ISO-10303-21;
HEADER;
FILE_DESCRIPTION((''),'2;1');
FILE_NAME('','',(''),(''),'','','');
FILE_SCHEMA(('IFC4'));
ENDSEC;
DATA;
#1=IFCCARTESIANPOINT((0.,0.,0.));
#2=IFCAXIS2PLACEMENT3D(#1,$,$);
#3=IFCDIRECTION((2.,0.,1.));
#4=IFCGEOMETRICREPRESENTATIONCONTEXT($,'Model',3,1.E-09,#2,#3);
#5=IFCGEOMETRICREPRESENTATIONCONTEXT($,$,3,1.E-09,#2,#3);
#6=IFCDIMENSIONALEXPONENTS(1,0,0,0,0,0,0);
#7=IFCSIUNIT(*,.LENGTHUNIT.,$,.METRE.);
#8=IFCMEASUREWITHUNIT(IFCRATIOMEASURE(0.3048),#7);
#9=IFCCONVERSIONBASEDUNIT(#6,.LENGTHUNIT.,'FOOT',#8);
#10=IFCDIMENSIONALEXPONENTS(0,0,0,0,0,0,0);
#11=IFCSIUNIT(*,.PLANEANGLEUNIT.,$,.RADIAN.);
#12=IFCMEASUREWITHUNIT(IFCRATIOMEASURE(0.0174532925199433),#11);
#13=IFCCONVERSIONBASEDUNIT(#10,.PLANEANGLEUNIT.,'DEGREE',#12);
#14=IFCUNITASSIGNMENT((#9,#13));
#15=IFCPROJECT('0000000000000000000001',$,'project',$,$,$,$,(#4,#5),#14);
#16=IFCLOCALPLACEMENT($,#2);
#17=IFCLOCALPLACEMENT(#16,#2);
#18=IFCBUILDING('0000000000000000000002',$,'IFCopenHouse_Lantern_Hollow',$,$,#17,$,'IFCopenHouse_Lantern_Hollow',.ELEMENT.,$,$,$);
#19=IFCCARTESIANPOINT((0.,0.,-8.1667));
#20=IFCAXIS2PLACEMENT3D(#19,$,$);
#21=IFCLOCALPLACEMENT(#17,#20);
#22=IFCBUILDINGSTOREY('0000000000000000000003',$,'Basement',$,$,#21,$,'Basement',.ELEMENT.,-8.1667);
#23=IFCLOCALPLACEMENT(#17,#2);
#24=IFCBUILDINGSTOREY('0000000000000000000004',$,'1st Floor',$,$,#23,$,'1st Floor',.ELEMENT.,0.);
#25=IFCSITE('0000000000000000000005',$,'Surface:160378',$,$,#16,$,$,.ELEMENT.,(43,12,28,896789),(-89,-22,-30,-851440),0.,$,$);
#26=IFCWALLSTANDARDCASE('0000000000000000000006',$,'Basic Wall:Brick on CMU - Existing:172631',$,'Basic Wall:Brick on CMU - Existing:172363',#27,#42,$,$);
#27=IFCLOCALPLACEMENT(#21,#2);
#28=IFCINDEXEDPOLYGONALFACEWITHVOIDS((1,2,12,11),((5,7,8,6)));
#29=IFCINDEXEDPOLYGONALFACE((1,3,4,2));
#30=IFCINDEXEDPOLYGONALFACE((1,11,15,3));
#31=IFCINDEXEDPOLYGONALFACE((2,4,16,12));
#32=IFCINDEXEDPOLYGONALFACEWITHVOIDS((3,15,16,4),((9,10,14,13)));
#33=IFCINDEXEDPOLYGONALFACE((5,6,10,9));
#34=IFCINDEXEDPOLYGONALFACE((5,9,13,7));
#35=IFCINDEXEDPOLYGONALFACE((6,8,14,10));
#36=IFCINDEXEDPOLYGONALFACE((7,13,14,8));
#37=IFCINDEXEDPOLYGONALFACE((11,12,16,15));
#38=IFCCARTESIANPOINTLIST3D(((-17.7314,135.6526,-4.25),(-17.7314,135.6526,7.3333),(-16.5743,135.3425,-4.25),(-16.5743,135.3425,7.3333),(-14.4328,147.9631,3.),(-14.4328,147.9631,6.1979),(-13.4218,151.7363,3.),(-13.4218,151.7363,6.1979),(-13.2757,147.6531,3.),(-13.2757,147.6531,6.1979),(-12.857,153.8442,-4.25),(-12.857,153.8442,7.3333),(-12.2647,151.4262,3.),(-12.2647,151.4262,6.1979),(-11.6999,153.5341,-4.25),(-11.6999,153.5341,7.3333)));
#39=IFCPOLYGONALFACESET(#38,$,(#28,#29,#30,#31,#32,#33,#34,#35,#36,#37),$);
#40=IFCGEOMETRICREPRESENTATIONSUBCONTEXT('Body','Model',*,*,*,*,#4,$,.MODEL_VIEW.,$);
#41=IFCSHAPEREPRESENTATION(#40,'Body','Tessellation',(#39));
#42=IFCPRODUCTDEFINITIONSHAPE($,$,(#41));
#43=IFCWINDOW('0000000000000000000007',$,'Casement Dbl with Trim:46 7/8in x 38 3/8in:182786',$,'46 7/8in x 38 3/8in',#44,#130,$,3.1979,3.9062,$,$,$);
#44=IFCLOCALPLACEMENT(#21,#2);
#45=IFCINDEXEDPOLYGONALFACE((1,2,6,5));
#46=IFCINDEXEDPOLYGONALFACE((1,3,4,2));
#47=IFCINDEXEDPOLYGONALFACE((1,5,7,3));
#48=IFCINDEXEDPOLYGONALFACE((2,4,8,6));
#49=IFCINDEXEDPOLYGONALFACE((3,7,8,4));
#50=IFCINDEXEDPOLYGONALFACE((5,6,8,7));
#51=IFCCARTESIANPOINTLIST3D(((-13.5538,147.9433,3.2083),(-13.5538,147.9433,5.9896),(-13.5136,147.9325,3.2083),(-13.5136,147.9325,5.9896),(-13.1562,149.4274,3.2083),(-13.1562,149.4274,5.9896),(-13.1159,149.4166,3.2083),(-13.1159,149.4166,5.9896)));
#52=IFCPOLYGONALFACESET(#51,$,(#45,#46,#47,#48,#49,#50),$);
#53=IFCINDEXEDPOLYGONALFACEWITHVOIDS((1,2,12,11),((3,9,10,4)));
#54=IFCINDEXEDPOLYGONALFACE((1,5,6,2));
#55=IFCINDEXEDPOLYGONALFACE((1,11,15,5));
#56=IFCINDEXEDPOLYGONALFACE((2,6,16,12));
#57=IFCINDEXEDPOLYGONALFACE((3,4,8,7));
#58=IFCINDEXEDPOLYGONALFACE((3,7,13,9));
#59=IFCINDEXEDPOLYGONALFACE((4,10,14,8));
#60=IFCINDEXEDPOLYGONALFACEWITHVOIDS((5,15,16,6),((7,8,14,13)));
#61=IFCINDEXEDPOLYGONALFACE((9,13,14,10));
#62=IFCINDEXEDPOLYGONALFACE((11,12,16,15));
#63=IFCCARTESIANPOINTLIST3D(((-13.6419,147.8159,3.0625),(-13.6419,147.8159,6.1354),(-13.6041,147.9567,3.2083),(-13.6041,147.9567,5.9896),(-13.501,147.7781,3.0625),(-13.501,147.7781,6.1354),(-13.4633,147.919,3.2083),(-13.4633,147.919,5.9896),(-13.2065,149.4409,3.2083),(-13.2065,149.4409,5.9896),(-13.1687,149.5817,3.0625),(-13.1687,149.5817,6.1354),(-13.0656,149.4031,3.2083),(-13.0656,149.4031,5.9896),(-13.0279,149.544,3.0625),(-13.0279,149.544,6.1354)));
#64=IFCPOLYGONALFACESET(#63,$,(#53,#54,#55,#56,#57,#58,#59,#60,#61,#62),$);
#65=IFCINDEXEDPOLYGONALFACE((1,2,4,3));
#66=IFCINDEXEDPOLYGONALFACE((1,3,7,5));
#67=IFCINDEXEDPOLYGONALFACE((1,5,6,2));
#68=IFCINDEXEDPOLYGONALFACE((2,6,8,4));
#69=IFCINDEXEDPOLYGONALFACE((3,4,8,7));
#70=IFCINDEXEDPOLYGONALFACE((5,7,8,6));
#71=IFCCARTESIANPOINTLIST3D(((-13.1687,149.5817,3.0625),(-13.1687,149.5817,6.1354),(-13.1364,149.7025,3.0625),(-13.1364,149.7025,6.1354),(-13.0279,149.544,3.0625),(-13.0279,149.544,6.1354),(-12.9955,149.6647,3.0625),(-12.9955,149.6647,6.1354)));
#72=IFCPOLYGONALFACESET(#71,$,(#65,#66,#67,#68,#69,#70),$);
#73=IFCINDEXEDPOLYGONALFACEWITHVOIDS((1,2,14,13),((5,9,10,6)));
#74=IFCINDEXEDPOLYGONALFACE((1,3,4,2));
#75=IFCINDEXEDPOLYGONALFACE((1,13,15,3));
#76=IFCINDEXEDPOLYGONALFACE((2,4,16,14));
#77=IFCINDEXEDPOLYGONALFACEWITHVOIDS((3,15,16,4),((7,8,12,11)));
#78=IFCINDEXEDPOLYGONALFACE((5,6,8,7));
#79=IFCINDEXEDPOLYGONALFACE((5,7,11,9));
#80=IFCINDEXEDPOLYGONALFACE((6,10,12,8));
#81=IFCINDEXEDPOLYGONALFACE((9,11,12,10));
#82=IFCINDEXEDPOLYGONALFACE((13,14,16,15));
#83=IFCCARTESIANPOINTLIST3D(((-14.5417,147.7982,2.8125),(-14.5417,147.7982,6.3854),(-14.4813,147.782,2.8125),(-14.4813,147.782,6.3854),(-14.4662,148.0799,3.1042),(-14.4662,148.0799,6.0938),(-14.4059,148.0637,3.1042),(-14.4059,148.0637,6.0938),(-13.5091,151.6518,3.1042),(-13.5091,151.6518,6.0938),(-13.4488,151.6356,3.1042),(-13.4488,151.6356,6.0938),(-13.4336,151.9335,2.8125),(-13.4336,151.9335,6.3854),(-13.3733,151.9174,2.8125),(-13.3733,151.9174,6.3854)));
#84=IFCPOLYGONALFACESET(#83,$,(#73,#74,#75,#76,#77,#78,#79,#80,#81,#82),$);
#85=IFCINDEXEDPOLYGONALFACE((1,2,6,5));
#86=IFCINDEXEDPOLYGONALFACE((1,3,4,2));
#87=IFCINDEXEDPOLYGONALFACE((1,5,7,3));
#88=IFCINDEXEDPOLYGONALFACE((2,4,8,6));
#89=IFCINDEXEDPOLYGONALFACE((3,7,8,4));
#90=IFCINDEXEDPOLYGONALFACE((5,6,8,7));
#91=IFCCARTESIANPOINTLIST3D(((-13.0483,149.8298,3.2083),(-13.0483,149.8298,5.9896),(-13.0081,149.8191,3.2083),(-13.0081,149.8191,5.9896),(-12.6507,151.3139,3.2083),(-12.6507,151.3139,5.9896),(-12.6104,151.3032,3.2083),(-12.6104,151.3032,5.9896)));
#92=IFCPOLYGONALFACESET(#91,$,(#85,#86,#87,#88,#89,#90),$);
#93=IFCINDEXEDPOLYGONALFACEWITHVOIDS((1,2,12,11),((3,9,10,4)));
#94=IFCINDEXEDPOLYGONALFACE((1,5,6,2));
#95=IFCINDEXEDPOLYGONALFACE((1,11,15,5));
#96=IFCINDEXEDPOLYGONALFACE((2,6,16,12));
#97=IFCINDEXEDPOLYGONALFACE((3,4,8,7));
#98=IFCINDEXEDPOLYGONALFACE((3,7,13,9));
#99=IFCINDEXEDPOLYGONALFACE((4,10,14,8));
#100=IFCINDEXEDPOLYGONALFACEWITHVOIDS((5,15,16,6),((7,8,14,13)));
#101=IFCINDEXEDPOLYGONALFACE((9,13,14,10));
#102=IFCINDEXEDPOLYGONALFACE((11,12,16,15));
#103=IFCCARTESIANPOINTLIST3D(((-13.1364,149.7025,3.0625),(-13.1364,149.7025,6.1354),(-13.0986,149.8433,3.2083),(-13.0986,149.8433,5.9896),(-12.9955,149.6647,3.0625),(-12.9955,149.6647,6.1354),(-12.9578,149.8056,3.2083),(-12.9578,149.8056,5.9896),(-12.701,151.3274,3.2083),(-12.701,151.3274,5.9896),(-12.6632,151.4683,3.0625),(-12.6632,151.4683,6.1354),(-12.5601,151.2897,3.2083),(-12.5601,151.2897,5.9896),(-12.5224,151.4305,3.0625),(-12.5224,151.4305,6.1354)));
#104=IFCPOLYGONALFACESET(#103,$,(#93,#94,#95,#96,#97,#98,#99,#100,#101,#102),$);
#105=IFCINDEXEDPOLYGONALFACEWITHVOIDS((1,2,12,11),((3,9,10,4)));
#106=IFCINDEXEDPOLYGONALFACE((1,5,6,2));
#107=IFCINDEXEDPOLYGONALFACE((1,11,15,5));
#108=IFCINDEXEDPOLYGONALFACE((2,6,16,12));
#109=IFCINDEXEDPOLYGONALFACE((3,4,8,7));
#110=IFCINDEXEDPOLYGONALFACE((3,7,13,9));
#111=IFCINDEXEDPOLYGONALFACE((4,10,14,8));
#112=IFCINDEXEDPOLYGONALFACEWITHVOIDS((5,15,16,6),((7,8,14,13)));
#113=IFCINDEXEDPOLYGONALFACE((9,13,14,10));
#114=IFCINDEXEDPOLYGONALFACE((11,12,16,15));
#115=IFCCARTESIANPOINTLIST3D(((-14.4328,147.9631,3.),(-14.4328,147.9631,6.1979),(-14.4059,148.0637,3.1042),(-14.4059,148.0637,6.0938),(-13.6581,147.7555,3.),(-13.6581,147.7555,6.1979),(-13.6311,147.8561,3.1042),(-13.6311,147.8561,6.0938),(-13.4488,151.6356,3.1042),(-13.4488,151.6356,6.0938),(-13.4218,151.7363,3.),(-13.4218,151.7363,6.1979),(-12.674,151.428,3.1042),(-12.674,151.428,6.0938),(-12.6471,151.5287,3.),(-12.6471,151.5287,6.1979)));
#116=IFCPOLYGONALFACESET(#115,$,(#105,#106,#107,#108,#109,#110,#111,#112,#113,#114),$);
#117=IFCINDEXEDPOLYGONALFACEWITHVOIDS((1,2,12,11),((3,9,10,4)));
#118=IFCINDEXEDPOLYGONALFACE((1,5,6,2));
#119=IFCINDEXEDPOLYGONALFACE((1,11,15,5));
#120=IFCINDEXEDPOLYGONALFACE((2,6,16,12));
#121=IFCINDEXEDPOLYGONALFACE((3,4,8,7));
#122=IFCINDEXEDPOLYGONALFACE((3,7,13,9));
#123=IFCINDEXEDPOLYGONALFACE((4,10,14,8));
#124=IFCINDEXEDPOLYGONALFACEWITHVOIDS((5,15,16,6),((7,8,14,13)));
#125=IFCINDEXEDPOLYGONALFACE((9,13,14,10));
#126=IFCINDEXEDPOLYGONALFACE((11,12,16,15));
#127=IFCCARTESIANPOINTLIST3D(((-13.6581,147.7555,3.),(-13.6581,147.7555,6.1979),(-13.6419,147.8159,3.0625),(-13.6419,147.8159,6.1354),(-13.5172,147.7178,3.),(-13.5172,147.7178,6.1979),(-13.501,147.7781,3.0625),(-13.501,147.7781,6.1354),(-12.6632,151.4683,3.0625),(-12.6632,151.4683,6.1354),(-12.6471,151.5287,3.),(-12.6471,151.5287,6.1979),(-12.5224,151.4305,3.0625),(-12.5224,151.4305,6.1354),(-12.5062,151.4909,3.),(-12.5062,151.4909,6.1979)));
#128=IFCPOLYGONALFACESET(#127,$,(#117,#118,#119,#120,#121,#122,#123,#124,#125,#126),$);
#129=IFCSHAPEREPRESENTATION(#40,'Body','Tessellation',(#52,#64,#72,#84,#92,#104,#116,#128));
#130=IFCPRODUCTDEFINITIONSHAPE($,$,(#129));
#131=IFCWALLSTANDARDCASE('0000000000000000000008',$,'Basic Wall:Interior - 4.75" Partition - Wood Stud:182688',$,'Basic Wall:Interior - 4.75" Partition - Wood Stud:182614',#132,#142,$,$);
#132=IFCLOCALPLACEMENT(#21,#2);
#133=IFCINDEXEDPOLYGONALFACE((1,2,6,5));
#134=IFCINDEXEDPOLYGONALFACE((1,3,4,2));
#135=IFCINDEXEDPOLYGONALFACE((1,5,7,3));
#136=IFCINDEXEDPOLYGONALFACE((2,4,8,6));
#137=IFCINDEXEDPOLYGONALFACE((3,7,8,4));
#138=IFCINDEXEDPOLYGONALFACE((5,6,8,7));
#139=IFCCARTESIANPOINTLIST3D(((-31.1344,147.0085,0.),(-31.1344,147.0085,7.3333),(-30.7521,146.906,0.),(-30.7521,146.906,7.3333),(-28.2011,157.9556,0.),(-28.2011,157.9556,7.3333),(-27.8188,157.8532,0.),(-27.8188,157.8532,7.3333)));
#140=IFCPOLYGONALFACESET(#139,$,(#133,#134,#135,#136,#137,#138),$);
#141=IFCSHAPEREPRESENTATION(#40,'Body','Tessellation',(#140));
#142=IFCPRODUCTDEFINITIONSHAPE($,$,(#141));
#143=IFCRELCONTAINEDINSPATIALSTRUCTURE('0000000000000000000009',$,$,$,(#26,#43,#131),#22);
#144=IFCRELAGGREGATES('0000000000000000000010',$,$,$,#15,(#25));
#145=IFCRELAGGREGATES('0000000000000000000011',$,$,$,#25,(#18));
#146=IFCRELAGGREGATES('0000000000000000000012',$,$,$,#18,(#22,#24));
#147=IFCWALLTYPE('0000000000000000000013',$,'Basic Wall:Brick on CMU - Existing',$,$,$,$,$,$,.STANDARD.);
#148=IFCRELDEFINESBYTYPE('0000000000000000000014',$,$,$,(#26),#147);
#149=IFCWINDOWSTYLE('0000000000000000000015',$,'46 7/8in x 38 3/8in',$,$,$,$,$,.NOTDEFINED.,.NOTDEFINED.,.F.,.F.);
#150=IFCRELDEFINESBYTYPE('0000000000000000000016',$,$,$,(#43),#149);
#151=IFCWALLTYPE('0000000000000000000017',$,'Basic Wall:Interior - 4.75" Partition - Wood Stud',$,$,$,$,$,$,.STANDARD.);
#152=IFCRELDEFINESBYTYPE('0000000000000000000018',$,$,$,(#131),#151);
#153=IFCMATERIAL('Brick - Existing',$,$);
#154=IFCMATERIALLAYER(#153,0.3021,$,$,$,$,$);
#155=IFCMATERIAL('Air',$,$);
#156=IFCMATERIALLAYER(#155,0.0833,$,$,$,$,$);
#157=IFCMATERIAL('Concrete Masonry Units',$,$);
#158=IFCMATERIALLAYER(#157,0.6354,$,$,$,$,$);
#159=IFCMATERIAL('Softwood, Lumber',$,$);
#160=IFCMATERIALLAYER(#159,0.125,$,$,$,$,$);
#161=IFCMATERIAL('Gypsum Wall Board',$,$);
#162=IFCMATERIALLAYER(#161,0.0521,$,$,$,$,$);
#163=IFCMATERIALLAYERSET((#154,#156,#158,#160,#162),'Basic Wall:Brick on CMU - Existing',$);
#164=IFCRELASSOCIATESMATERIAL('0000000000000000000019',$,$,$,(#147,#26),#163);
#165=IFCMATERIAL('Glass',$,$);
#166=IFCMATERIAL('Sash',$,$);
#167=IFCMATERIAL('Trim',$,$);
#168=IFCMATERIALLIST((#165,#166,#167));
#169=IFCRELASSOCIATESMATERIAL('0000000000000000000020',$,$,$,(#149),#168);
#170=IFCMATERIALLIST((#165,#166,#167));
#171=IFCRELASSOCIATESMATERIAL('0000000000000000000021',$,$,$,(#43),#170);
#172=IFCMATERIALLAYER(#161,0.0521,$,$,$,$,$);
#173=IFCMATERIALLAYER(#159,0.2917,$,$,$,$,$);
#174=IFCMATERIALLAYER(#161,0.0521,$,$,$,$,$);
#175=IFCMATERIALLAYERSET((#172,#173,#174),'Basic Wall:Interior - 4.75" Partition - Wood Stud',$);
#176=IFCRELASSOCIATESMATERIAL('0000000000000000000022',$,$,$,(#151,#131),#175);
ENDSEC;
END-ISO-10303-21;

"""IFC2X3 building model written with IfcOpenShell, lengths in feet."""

from ifc_helpers import new_model, entity, si_unit, converted_unit, direction, frame, frame_2d, origin, place, context, subcontext, project, spatial, polyline, rectangle, outline, extrude, source, transform, mapped, material, material_list, layer, layer_set, layer_usage, type_object, type_shapes, element, fill, save


model = new_model("IFC2X3")

# Units and contexts
model_context = context("Model", 3, precision=1e-09, world=origin(), true_north=direction((2.0, 0.0, 1.0)))
context_of_model = context(None, 3, precision=1e-09, world=origin(), true_north=direction((2.0, 0.0, 1.0)))
body_context = subcontext(model_context, "Body", "Model", "MODEL_VIEW")
ifc_project = project(units=[converted_unit("LENGTHUNIT", "FOOT", entity("IfcRatioMeasure", 0.3048), si_unit("LENGTHUNIT", "METRE"), dimensions=[1, 0, 0, 0, 0, 0, 0]), converted_unit("PLANEANGLEUNIT", "DEGREE", entity("IfcRatioMeasure", 0.0174532925199433), si_unit("PLANEANGLEUNIT", "RADIAN"), dimensions=[0, 0, 0, 0, 0, 0, 0])], contexts=[model_context, context_of_model])

# Site, building, storey
site_placement = place(None, origin())
site = spatial("IfcSite", under=ifc_project, at=site_placement, Name="Surface:160378", CompositionType="ELEMENT", RefLatitude=(43, 12, 28, 896789), RefLongitude=(-89, -22, -30, -851440), RefElevation=0.0)
building_placement = place(site_placement, origin())
building = spatial("IfcBuilding", under=site, at=building_placement, Name="IFCopenHouse_Lantern_Hollow", LongName="IFCopenHouse_Lantern_Hollow", CompositionType="ELEMENT")
storey_1_placement = place(building_placement, frame((0.0, 0.0, -8.1667)))
storey_1 = spatial("IfcBuildingStorey", under=building, at=storey_1_placement, Name="Basement", LongName="Basement", CompositionType="ELEMENT", Elevation=-8.1667)

# Shared definitions
ifc_material_1 = material(Name="Concrete Masonry Units")

# Wall, opening, window
ifc_material_2 = material(Name="Brick - Existing")
ifc_layer_1 = layer(ifc_material_2, 0.3021)
ifc_material_3 = material(Name="Air")
ifc_layer_2 = layer(ifc_material_3, 0.0833)
ifc_layer_3 = layer(ifc_material_1, 0.6354)
ifc_material_4 = material(Name="Softwood, Lumber")
ifc_layer_4 = layer(ifc_material_4, 0.125)
ifc_material_5 = material(Name="Gypsum Wall Board")
ifc_layer_5 = layer(ifc_material_5, 0.0521)
ifc_layer_set_1 = layer_set([ifc_layer_1, ifc_layer_2, ifc_layer_3, ifc_layer_4, ifc_layer_5], Name="Basic Wall:Brick on CMU - Existing")
ifc_layer_usage_1 = layer_usage(ifc_layer_set_1, "AXIS2", "NEGATIVE", 0.599)
wall_type_1 = type_object("IfcWallType", Name="Basic Wall:Brick on CMU - Existing", PredefinedType="STANDARD", material=ifc_layer_set_1)
wall_1_placement = place(storey_1_placement, frame((-12.2784, 153.6892, -4.25), z_axis=(0.0, 0.0, 1.0), x_axis=(-0.258819, -0.965926, 0.0)))
wall_1 = element("IfcWallStandardCase", 1, at=wall_1_placement, inside=storey_1, type_object=wall_type_1, material=ifc_layer_usage_1, Name="Basic Wall:Brick on CMU - Existing:172631", ObjectType="Basic Wall:Brick on CMU - Existing:172363", context=body_context, shape_type="SweptSolid", body=[
    extrude(rectangle(XDim=18.8333, YDim=1.1979, at=frame_2d((9.4167, 0.0), x_axis=(-1.0, 0.0))), origin(), (0.0, 0.0, 1.0), 11.5833),
])
opening_1_placement = place(wall_1_placement, frame((2.1823, -0.599, 7.25)))
opening_1 = element("IfcOpeningElement", 2, at=opening_1_placement, cuts=wall_1, ObjectType="Opening", context=body_context, shape_type="SweptSolid", body=[
    extrude(rectangle(XDim=3.1979, YDim=3.9062, at=frame_2d((1.599, 1.9531), x_axis=(-1.0, 0.0))), frame((0.0, 0.0, 0.0), z_axis=(0.0, 1.0, 0.0), x_axis=(0.0, 0.0, 1.0)), (0.0, 0.0, 1.0), 1.1979),
])
ifc_material_6 = material(Name="Glass")
ifc_material_7 = material(Name="Sash")
ifc_material_8 = material(Name="Trim")
ifc_material_list_1 = material_list([ifc_material_6, ifc_material_7, ifc_material_8])
ifc_material_list_2 = material_list([ifc_material_6, ifc_material_7, ifc_material_8])
window_style_1 = type_object("IfcWindowStyle", Name="46 7/8in x 38 3/8in", ConstructionType="NOTDEFINED", OperationType="NOTDEFINED", ParameterTakesPrecedence=False, Sizeable=False, material=ifc_material_list_2)
shared_shape_1 = source(origin(), body_context, "Body", "SweptSolid", [
    extrude(rectangle(XDim=0.0417, YDim=1.5365, at=frame_2d((0.0, 0.0), x_axis=(1.0, 0.0))), frame((2.9297, 0.875, 0.2083), z_axis=(0.0, 0.0, 1.0), x_axis=(0.0, -1.0, 0.0)), (0.0, 0.0, 1.0), 2.7813),
    extrude(outline(polyline([(-0.9141, -1.5365), (0.9141, -1.5365), (0.9141, 1.5365), (-0.9141, 1.5365), (-0.9141, -1.5365)]), holes=[polyline([(-0.7682, -1.3906), (-0.7682, 1.3906), (0.7682, 1.3906), (0.7682, -1.3906), (-0.7682, -1.3906)])]), frame((2.9297, 0.8021, 1.599), z_axis=(0.0, 1.0, 0.0), x_axis=(1.0, 0.0, 0.0)), (0.0, 0.0, 1.0), 0.1458),
    extrude(rectangle(XDim=0.1458, YDim=0.125, at=frame_2d((0.0, 0.0), x_axis=(1.0, 0.0))), frame((1.9531, 0.875, 0.0625), z_axis=(0.0, 0.0, 1.0), x_axis=(0.0, 1.0, 0.0)), (0.0, 0.0, 1.0), 3.0729),
    extrude(outline(polyline([(-1.7865, -2.1406), (1.7865, -2.1406), (1.7865, 2.1406), (-1.7865, 2.1406), (-1.7865, -2.1406)]), holes=[polyline([(-1.4948, -1.849), (-1.4948, 1.849), (1.4948, 1.849), (1.4948, -1.849), (-1.4948, -1.849)])]), frame((1.9531, -0.0625, 1.599), z_axis=(0.0, 1.0, 0.0), x_axis=(0.0, 0.0, -1.0)), (0.0, 0.0, 1.0), 0.0625),
    extrude(rectangle(XDim=0.0417, YDim=1.5365, at=frame_2d((0.0, 0.0), x_axis=(1.0, 0.0))), frame((0.9766, 0.875, 0.2083), z_axis=(0.0, 0.0, 1.0), x_axis=(0.0, 1.0, 0.0)), (0.0, 0.0, 1.0), 2.7813),
    extrude(outline(polyline([(-0.9141, -1.5365), (0.9141, -1.5365), (0.9141, 1.5365), (-0.9141, 1.5365), (-0.9141, -1.5365)]), holes=[polyline([(-0.7682, -1.3906), (-0.7682, 1.3906), (0.7682, 1.3906), (0.7682, -1.3906), (-0.7682, -1.3906)])]), frame((0.9766, 0.8021, 1.599), z_axis=(0.0, 1.0, 0.0), x_axis=(1.0, 0.0, 0.0)), (0.0, 0.0, 1.0), 0.1458),
    extrude(outline(polyline([(-1.9531, -1.599), (1.9531, -1.599), (1.9531, 1.599), (-1.9531, 1.599), (-1.9531, -1.599)]), holes=[polyline([(-1.849, -1.4948), (-1.849, 1.4948), (1.849, 1.4948), (1.849, -1.4948), (-1.849, -1.4948)])]), frame((1.9531, 0.0, 1.599), z_axis=(0.0, 1.0, 0.0), x_axis=(1.0, 0.0, 0.0)), (0.0, 0.0, 1.0), 0.8021),
    extrude(outline(polyline([(-1.599, -1.9531), (1.599, -1.9531), (1.599, 1.9531), (-1.599, 1.9531), (-1.599, -1.9531)]), holes=[polyline([(-1.5365, -1.8906), (-1.5365, 1.8906), (1.5365, 1.8906), (1.5365, -1.8906), (-1.5365, -1.8906)])]), frame((1.9531, 0.8021, 1.599), z_axis=(0.0, 1.0, 0.0), x_axis=(0.0, 0.0, -1.0)), (0.0, 0.0, 1.0), 0.1458),
])
type_shapes(window_style_1, [shared_shape_1])
window_1_placement = place(storey_1_placement, frame((-13.4218, 151.7363, 3.0), z_axis=(0.0, 0.0, 1.0), x_axis=(-0.258819, -0.965926, 0.0)))
window_1 = element("IfcWindow", 3, at=window_1_placement, inside=storey_1, type_object=window_style_1, material=ifc_material_list_1, Name="Casement Dbl with Trim:46 7/8in x 38 3/8in:182786", ObjectType="46 7/8in x 38 3/8in", OverallHeight=3.1979, OverallWidth=3.9062, context=body_context, shape_type="MappedRepresentation", body=[
    mapped(shared_shape_1, transform((0.0, 0.0, 0.0), scale=1.0)),
])
fill(opening_1, window_1)

# Wall
ifc_layer_6 = layer(ifc_material_5, 0.0521)
ifc_layer_7 = layer(ifc_material_4, 0.2917)
ifc_layer_8 = layer(ifc_material_5, 0.0521)
ifc_layer_set_2 = layer_set([ifc_layer_6, ifc_layer_7, ifc_layer_8], Name="Basic Wall:Interior - 4.75\" Partition - Wood Stud")
ifc_layer_usage_2 = layer_usage(ifc_layer_set_2, "AXIS2", "NEGATIVE", 0.1979)
wall_type_2 = type_object("IfcWallType", Name="Basic Wall:Interior - 4.75\" Partition - Wood Stud", PredefinedType="STANDARD", material=ifc_layer_set_2)
wall_2_placement = place(storey_1_placement, frame((-28.0099, 157.9044, 0.0), z_axis=(0.0, 0.0, 1.0), x_axis=(-0.258819, -0.965926, 0.0)))
element("IfcWallStandardCase", 4, at=wall_2_placement, inside=storey_1, type_object=wall_type_2, material=ifc_layer_usage_2, Name="Basic Wall:Interior - 4.75\" Partition - Wood Stud:182688", ObjectType="Basic Wall:Interior - 4.75\" Partition - Wood Stud:182614", context=body_context, shape_type="SweptSolid", body=[
    extrude(rectangle(XDim=11.3333, YDim=0.3958, at=frame_2d((5.6667, 0.0), x_axis=(-1.0, 0.0))), origin(), (0.0, 0.0, 1.0), 7.3333),
])

# Shared definitions
storey_2_placement = place(building_placement, origin())
storey_2 = spatial("IfcBuildingStorey", under=building, at=storey_2_placement, Name="1st Floor", LongName="1st Floor", CompositionType="ELEMENT", Elevation=0.0)

save(model, "model.ifc")
